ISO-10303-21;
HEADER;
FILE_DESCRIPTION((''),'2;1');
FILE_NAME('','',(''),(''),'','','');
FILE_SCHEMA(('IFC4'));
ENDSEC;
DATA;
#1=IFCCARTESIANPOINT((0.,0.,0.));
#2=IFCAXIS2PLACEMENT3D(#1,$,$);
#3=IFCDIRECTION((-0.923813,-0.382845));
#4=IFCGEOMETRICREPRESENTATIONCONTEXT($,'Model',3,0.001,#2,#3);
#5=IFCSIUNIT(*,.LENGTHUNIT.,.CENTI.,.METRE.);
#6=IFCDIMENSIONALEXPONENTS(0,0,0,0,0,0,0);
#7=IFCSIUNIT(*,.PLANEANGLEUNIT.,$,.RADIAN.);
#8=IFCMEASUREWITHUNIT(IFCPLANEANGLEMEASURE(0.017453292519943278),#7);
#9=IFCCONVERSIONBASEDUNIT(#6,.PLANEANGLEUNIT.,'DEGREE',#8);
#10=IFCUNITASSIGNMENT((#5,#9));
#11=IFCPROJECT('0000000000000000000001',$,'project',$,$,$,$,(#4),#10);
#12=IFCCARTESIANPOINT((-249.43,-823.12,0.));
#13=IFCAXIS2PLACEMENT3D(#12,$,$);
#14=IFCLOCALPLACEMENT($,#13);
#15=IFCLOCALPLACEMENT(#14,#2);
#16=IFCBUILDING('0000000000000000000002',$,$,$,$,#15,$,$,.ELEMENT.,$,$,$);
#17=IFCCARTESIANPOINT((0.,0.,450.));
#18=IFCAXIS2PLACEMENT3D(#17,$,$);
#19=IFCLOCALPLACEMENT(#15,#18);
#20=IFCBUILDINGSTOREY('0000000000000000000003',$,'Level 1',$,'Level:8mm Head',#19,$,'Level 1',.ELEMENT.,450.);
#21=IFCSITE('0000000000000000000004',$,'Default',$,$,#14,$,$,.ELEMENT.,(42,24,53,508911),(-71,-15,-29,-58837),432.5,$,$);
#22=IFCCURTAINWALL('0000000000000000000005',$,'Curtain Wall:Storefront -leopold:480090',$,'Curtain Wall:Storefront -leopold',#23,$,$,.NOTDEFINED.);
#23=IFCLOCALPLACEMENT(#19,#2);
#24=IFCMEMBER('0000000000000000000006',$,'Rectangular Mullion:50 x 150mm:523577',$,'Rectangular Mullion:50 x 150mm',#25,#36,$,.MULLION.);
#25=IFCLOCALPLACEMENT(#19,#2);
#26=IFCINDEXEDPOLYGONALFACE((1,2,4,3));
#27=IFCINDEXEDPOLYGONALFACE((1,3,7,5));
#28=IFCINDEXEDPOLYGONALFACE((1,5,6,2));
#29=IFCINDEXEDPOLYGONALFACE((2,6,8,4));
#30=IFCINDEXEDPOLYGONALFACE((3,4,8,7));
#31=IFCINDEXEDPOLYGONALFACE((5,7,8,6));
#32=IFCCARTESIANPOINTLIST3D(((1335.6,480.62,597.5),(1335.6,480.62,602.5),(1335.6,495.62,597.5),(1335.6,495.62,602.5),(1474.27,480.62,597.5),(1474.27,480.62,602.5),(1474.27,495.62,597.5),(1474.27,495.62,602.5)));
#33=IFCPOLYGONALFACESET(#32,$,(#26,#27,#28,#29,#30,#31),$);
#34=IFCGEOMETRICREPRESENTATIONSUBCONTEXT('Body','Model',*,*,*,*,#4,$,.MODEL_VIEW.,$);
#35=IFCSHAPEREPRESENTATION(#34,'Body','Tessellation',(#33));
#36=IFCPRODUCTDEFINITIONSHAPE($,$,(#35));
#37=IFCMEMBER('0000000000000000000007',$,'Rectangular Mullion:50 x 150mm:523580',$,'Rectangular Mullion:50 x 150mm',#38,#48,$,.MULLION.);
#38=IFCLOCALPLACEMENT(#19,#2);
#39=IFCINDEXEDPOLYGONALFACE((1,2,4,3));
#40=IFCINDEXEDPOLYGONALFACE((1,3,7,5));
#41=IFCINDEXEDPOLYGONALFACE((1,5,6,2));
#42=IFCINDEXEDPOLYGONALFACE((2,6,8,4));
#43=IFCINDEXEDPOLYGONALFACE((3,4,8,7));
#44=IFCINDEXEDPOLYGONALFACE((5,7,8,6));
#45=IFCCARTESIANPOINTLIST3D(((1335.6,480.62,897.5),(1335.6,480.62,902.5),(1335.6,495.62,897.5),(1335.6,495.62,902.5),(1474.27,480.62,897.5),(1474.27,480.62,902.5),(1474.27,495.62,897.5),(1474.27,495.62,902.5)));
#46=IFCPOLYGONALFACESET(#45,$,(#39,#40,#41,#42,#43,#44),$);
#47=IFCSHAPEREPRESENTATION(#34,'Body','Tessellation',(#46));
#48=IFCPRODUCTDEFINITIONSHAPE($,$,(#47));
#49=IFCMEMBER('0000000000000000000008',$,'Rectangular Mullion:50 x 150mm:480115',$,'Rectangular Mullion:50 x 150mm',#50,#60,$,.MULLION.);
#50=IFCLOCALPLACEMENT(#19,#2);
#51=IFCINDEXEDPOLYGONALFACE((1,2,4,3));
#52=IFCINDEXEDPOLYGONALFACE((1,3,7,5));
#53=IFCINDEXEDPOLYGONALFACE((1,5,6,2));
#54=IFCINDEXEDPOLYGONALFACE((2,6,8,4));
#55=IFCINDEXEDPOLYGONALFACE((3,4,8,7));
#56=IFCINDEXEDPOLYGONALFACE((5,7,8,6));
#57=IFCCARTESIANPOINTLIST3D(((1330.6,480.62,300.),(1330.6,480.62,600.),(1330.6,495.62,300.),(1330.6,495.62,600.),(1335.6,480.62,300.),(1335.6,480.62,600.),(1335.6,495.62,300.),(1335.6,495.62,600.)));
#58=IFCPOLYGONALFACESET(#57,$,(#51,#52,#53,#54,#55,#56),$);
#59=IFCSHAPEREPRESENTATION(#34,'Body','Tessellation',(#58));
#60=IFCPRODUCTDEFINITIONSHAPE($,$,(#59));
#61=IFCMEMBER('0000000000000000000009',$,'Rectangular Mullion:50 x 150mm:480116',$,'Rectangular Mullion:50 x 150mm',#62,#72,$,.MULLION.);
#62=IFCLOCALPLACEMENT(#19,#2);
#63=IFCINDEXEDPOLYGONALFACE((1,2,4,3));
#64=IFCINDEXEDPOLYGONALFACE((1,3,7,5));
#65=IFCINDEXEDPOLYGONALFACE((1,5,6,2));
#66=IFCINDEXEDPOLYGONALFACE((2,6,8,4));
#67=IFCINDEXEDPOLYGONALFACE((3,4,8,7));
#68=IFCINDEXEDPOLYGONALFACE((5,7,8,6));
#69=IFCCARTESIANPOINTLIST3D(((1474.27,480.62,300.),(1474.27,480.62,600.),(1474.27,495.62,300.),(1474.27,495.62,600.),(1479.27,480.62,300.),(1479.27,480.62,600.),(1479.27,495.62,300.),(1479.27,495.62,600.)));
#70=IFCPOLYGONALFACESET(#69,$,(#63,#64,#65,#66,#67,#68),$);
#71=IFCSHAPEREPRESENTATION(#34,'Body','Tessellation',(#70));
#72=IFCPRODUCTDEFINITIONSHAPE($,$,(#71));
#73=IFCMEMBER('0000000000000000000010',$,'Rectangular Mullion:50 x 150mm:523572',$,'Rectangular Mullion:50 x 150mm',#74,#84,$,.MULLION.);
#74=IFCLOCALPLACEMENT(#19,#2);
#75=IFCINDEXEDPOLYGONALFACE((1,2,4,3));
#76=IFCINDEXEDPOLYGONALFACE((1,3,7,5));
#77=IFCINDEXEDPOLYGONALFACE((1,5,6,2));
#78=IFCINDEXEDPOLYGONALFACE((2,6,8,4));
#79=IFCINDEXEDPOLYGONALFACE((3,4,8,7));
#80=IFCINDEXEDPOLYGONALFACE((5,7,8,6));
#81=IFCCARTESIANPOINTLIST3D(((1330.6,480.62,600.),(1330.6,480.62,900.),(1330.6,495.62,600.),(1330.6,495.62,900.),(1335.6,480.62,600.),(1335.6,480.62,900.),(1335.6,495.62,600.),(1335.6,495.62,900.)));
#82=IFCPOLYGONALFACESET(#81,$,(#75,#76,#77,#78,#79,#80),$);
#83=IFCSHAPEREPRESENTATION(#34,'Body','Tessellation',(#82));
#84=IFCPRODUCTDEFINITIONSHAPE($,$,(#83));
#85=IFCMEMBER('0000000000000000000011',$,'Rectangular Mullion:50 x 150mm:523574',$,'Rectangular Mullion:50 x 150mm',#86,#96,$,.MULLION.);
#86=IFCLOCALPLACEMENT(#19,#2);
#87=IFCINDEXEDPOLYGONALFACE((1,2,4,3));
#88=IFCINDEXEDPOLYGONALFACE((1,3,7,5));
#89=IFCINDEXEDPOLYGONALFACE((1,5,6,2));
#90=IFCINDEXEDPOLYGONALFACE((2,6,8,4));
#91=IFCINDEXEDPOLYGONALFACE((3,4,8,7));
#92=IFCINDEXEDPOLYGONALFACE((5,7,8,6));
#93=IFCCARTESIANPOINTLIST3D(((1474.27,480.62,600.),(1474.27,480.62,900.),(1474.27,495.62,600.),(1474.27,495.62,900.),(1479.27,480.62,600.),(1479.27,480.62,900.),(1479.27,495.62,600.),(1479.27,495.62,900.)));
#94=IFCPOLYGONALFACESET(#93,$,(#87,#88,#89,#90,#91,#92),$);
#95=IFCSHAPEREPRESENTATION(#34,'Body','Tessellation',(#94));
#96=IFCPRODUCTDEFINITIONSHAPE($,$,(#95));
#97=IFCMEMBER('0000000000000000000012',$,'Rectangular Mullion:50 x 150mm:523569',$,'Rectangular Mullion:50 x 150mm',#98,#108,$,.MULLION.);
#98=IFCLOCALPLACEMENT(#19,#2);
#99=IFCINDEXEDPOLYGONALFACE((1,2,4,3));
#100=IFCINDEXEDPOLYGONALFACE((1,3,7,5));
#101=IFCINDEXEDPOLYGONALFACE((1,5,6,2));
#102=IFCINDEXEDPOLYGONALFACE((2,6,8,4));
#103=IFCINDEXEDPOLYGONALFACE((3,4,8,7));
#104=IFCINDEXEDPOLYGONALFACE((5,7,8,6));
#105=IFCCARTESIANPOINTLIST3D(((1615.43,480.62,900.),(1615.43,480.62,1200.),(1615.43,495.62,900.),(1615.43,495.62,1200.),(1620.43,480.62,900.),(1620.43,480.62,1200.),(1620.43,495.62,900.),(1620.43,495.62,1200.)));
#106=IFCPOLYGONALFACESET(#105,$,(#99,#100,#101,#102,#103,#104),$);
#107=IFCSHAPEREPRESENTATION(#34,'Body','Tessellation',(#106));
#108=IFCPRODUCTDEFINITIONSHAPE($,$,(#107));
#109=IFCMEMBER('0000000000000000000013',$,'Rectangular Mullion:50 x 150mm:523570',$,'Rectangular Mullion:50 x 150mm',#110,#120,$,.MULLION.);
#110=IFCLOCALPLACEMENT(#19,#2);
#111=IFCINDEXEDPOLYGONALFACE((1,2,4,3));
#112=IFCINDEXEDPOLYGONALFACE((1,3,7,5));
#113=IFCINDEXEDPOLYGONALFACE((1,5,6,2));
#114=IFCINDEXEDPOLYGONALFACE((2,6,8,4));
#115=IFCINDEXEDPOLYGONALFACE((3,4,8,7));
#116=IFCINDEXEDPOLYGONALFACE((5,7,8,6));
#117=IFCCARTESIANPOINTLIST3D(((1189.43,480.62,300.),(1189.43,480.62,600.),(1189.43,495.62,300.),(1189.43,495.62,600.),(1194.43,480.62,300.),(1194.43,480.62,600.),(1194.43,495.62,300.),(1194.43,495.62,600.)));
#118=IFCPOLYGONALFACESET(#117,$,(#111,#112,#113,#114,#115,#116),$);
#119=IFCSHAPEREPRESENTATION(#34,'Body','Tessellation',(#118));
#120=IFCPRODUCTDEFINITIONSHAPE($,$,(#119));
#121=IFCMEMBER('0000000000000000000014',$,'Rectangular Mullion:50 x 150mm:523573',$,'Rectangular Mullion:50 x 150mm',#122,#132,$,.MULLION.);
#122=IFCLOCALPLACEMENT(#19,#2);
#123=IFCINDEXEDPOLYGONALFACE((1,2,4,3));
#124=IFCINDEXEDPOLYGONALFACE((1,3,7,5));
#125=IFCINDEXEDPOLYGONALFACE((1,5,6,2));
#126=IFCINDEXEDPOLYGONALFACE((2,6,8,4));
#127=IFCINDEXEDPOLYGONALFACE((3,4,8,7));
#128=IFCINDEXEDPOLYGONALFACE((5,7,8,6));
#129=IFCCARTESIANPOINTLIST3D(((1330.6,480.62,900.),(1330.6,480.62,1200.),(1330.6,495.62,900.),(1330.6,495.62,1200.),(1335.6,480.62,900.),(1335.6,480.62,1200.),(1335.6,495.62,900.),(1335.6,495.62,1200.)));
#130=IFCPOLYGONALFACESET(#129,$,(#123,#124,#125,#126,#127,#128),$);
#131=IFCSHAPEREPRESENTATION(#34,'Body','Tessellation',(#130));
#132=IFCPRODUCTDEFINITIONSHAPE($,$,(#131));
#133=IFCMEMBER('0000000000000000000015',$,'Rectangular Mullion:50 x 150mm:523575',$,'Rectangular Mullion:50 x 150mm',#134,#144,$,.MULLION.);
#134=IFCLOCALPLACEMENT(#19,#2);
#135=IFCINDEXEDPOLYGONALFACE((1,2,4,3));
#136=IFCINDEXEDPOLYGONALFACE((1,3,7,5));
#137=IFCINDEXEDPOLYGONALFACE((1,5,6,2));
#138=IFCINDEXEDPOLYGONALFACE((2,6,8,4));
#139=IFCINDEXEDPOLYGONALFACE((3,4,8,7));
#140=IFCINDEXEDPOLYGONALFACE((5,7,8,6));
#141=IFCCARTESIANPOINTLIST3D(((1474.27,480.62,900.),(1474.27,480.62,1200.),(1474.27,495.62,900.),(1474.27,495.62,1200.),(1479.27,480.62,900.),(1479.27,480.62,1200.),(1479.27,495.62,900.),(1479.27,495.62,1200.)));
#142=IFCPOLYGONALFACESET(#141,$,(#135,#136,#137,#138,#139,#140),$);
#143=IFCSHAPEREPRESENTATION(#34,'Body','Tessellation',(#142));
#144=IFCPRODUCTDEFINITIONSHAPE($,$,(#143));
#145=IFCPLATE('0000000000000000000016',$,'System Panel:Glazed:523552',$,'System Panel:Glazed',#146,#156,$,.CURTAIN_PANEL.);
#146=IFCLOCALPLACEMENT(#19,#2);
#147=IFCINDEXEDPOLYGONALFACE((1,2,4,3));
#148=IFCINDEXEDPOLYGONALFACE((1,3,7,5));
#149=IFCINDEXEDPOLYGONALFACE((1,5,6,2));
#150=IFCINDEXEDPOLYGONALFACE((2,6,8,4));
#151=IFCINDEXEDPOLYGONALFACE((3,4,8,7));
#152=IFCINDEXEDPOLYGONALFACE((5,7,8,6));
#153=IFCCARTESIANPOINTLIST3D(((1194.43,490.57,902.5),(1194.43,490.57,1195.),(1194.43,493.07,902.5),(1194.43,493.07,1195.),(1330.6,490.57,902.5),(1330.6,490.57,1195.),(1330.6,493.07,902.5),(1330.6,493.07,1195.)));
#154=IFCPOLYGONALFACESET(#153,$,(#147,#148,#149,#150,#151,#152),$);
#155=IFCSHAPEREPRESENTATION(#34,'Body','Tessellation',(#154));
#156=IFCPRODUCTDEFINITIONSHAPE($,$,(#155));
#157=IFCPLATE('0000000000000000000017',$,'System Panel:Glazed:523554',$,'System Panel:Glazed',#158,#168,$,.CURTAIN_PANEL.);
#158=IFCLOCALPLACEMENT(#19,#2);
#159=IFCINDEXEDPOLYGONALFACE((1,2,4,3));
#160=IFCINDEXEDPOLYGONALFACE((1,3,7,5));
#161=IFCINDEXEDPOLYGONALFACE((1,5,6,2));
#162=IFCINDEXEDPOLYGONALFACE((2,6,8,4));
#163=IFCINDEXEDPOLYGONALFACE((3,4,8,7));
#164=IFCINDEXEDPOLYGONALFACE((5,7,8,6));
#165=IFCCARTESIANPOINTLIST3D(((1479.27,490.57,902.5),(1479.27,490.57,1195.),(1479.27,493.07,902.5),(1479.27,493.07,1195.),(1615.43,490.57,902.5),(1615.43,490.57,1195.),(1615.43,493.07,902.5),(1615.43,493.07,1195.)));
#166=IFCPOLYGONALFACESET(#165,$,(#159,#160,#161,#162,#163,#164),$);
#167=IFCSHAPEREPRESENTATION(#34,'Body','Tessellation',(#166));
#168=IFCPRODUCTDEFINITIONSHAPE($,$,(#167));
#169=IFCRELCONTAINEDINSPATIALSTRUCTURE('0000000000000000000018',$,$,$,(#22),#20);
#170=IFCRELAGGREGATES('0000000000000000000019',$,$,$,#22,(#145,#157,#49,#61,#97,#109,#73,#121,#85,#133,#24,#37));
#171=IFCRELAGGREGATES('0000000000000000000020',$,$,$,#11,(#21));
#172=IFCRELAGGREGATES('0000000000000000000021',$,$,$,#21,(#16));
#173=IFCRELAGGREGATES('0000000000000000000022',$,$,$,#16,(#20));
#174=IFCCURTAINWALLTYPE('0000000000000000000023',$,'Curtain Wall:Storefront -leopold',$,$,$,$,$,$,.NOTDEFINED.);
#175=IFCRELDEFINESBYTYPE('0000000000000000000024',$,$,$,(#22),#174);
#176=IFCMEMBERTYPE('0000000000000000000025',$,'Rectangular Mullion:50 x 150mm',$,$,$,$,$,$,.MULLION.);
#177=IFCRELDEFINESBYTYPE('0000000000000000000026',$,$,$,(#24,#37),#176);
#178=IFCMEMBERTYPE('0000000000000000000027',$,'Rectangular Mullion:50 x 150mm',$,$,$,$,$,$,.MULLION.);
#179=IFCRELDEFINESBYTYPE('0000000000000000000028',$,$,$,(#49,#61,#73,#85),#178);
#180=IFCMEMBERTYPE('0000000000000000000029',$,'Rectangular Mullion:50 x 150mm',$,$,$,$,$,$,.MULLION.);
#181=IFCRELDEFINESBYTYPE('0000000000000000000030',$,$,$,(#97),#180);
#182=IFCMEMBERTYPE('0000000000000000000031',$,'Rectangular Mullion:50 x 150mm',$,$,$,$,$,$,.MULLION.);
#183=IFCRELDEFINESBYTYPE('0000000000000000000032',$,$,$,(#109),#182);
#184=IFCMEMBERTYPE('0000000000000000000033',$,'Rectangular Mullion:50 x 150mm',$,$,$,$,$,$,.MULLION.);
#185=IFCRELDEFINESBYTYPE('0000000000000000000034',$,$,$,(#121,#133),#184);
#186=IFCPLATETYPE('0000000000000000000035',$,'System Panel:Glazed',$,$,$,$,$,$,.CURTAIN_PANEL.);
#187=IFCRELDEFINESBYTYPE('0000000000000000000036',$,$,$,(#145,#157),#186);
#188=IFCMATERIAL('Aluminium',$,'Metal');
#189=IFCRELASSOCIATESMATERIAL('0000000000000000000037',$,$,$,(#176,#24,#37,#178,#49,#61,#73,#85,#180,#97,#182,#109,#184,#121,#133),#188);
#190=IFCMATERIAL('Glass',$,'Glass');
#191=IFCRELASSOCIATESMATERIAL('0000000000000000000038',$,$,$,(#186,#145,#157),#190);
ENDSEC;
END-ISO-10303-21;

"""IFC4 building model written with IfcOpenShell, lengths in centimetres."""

from ifc_helpers import new_model, entity, si_unit, converted_unit, direction, frame, origin, place, context, subcontext, project, spatial, indexed_curve, outline, extrude, source, transform, mapped, material, type_object, type_shapes, element, aggregate, save


model = new_model("IFC4")

# Units and contexts
model_context = context("Model", 3, precision=0.001, world=origin(), true_north=direction((-0.923813, -0.382845)))
body_context = subcontext(model_context, "Body", "Model", "MODEL_VIEW")
ifc_project = project(units=[si_unit("LENGTHUNIT", "METRE", prefix="CENTI"), converted_unit("PLANEANGLEUNIT", "DEGREE", entity("IfcPlaneAngleMeasure", 0.017453292519943278), si_unit("PLANEANGLEUNIT", "RADIAN"), dimensions=[0, 0, 0, 0, 0, 0, 0])], contexts=[model_context])

# Site, building, storey
site_placement = place(None, frame((-249.43, -823.12, 0.0)))
site = spatial("IfcSite", under=ifc_project, at=site_placement, Name="Default", CompositionType="ELEMENT", RefLatitude=(42, 24, 53, 508911), RefLongitude=(-71, -15, -29, -58837), RefElevation=432.5)
building_placement = place(site_placement, origin())
building = spatial("IfcBuilding", under=site, at=building_placement, CompositionType="ELEMENT")
storey_placement = place(building_placement, frame((0.0, 0.0, 450.0)))
storey = spatial("IfcBuildingStorey", under=building, at=storey_placement, Name="Level 1", ObjectType="Level:8mm Head", LongName="Level 1", CompositionType="ELEMENT", Elevation=450.0)

# Curtain wall, members, plates
curtain_wall_type = type_object("IfcCurtainWallType", Name="Curtain Wall:Storefront -leopold", PredefinedType="NOTDEFINED")
curtain_wall_placement = place(storey_placement, frame((0.0, 0.0, -450.0)))
curtain_wall = element("IfcCurtainWall", 1, at=curtain_wall_placement, inside=storey, type_object=curtain_wall_type, Name="Curtain Wall:Storefront -leopold:480090", ObjectType="Curtain Wall:Storefront -leopold", PredefinedType="NOTDEFINED")
ifc_material_1 = material(Name="Aluminium", Category="Metal")
member_type_1 = type_object("IfcMemberType", Name="Rectangular Mullion:50 x 150mm", PredefinedType="MULLION", material=ifc_material_1)
shared_shape_1 = source(origin(), body_context, "Body", "SweptSolid", [
    extrude(outline(indexed_curve([(-2.5, -7.5), (2.5, -7.5), (2.5, 7.5), (-2.5, 7.5), (-2.5, -7.5)], self_intersect=False)), frame((0.0, 0.0, -138.67), z_axis=(0.0, 0.0, 1.0), x_axis=(-1.0, 0.0, 0.0)), (0.0, 0.0, 1.0), 138.67),
])
type_shapes(member_type_1, [shared_shape_1])
member_1_placement = place(curtain_wall_placement, frame((1474.27, 488.12, 1050.0), z_axis=(1.0, 0.0, 0.0), x_axis=(0.0, 0.0, 1.0)))
member_1 = element("IfcMember", 2, at=member_1_placement, type_object=member_type_1, material=ifc_material_1, Name="Rectangular Mullion:50 x 150mm:523577", ObjectType="Rectangular Mullion:50 x 150mm", PredefinedType="MULLION", context=body_context, shape_type="MappedRepresentation", body=[
    mapped(shared_shape_1, transform((0.0, 0.0, 0.0), scale=1.0)),
])
member_2_placement = place(curtain_wall_placement, frame((1474.27, 488.12, 1350.0), z_axis=(1.0, 0.0, 0.0), x_axis=(0.0, 0.0, 1.0)))
member_2 = element("IfcMember", 3, at=member_2_placement, type_object=member_type_1, material=ifc_material_1, Name="Rectangular Mullion:50 x 150mm:523580", ObjectType="Rectangular Mullion:50 x 150mm", PredefinedType="MULLION", context=body_context, shape_type="MappedRepresentation", body=[
    mapped(shared_shape_1, transform((0.0, 0.0, 0.0), scale=1.0)),
])
member_type_2 = type_object("IfcMemberType", Name="Rectangular Mullion:50 x 150mm", PredefinedType="MULLION", material=ifc_material_1)
shared_shape_2 = source(origin(), body_context, "Body", "SweptSolid", [
    extrude(outline(indexed_curve([(-2.5, -7.5), (2.5, -7.5), (2.5, 7.5), (-2.5, 7.5), (-2.5, -7.5)], self_intersect=False)), frame((0.0, 0.0, -300.0), z_axis=(0.0, 0.0, 1.0), x_axis=(-1.0, 0.0, 0.0)), (0.0, 0.0, 1.0), 300.0),
])
type_shapes(member_type_2, [shared_shape_2])
member_3_placement = place(curtain_wall_placement, frame((1333.1, 488.12, 750.0), z_axis=(0.0, 0.0, -1.0), x_axis=(1.0, 0.0, 0.0)))
member_3 = element("IfcMember", 4, at=member_3_placement, type_object=member_type_2, material=ifc_material_1, Name="Rectangular Mullion:50 x 150mm:480115", ObjectType="Rectangular Mullion:50 x 150mm", PredefinedType="MULLION", context=body_context, shape_type="MappedRepresentation", body=[
    mapped(shared_shape_2, transform((0.0, 0.0, 0.0), scale=1.0)),
])
member_4_placement = place(curtain_wall_placement, frame((1476.77, 488.12, 750.0), z_axis=(0.0, 0.0, -1.0), x_axis=(1.0, 0.0, 0.0)))
member_4 = element("IfcMember", 5, at=member_4_placement, type_object=member_type_2, material=ifc_material_1, Name="Rectangular Mullion:50 x 150mm:480116", ObjectType="Rectangular Mullion:50 x 150mm", PredefinedType="MULLION", context=body_context, shape_type="MappedRepresentation", body=[
    mapped(shared_shape_2, transform((0.0, 0.0, 0.0), scale=1.0)),
])
member_5_placement = place(curtain_wall_placement, frame((1333.1, 488.12, 1050.0), z_axis=(0.0, 0.0, -1.0), x_axis=(1.0, 0.0, 0.0)))
member_5 = element("IfcMember", 6, at=member_5_placement, type_object=member_type_2, material=ifc_material_1, Name="Rectangular Mullion:50 x 150mm:523572", ObjectType="Rectangular Mullion:50 x 150mm", PredefinedType="MULLION", context=body_context, shape_type="MappedRepresentation", body=[
    mapped(shared_shape_2, transform((0.0, 0.0, 0.0), scale=1.0)),
])
member_6_placement = place(curtain_wall_placement, frame((1476.77, 488.12, 1050.0), z_axis=(0.0, 0.0, -1.0), x_axis=(1.0, 0.0, 0.0)))
member_6 = element("IfcMember", 7, at=member_6_placement, type_object=member_type_2, material=ifc_material_1, Name="Rectangular Mullion:50 x 150mm:523574", ObjectType="Rectangular Mullion:50 x 150mm", PredefinedType="MULLION", context=body_context, shape_type="MappedRepresentation", body=[
    mapped(shared_shape_2, transform((0.0, 0.0, 0.0), scale=1.0)),
])
member_type_3 = type_object("IfcMemberType", Name="Rectangular Mullion:50 x 150mm", PredefinedType="MULLION", material=ifc_material_1)
shared_shape_3 = source(origin(), body_context, "Body", "SweptSolid", [
    extrude(outline(indexed_curve([(-2.5, -7.5), (2.5, -7.5), (2.5, 7.5), (-2.5, 7.5), (-2.5, -7.5)], self_intersect=False)), frame((-2.5, 0.0, -300.0), z_axis=(0.0, 0.0, 1.0), x_axis=(-1.0, 0.0, 0.0)), (0.0, 0.0, 1.0), 300.0),
])
type_shapes(member_type_3, [shared_shape_3])
member_7_placement = place(curtain_wall_placement, frame((1620.43, 488.12, 1350.0), z_axis=(0.0, 0.0, -1.0), x_axis=(1.0, 0.0, 0.0)))
member_7 = element("IfcMember", 8, at=member_7_placement, type_object=member_type_3, material=ifc_material_1, Name="Rectangular Mullion:50 x 150mm:523569", ObjectType="Rectangular Mullion:50 x 150mm", PredefinedType="MULLION", context=body_context, shape_type="MappedRepresentation", body=[
    mapped(shared_shape_3, transform((0.0, 0.0, 0.0), scale=1.0)),
])
member_type_4 = type_object("IfcMemberType", Name="Rectangular Mullion:50 x 150mm", PredefinedType="MULLION", material=ifc_material_1)
shared_shape_4 = source(origin(), body_context, "Body", "SweptSolid", [
    extrude(outline(indexed_curve([(-2.5, -7.5), (2.5, -7.5), (2.5, 7.5), (-2.5, 7.5), (-2.5, -7.5)], self_intersect=False)), frame((-2.5, 0.0, -300.0), z_axis=(0.0, 0.0, 1.0), x_axis=(-1.0, 0.0, 0.0)), (0.0, 0.0, 1.0), 300.0),
])
type_shapes(member_type_4, [shared_shape_4])
member_8_placement = place(curtain_wall_placement, frame((1189.43, 488.12, 1050.0), z_axis=(0.0, 0.0, 1.0), x_axis=(-1.0, 0.0, 0.0)))
member_8 = element("IfcMember", 9, at=member_8_placement, type_object=member_type_4, material=ifc_material_1, Name="Rectangular Mullion:50 x 150mm:523570", ObjectType="Rectangular Mullion:50 x 150mm", PredefinedType="MULLION", context=body_context, shape_type="MappedRepresentation", body=[
    mapped(shared_shape_4, transform((0.0, 0.0, 0.0), scale=1.0)),
])
member_type_5 = type_object("IfcMemberType", Name="Rectangular Mullion:50 x 150mm", PredefinedType="MULLION", material=ifc_material_1)
shared_shape_5 = source(origin(), body_context, "Body", "SweptSolid", [
    extrude(outline(indexed_curve([(-2.5, -7.5), (2.5, -7.5), (2.5, 7.5), (-2.5, 7.5), (-2.5, -7.5)], self_intersect=False)), frame((0.0, 0.0, -300.0), z_axis=(0.0, 0.0, 1.0), x_axis=(-1.0, 0.0, 0.0)), (0.0, 0.0, 1.0), 300.0),
])
type_shapes(member_type_5, [shared_shape_5])
member_9_placement = place(curtain_wall_placement, frame((1333.1, 488.12, 1350.0), z_axis=(0.0, 0.0, -1.0), x_axis=(1.0, 0.0, 0.0)))
member_9 = element("IfcMember", 10, at=member_9_placement, type_object=member_type_5, material=ifc_material_1, Name="Rectangular Mullion:50 x 150mm:523573", ObjectType="Rectangular Mullion:50 x 150mm", PredefinedType="MULLION", context=body_context, shape_type="MappedRepresentation", body=[
    mapped(shared_shape_5, transform((0.0, 0.0, 0.0), scale=1.0)),
])
member_10_placement = place(curtain_wall_placement, frame((1476.77, 488.12, 1350.0), z_axis=(0.0, 0.0, -1.0), x_axis=(1.0, 0.0, 0.0)))
member_10 = element("IfcMember", 11, at=member_10_placement, type_object=member_type_5, material=ifc_material_1, Name="Rectangular Mullion:50 x 150mm:523575", ObjectType="Rectangular Mullion:50 x 150mm", PredefinedType="MULLION", context=body_context, shape_type="MappedRepresentation", body=[
    mapped(shared_shape_5, transform((0.0, 0.0, 0.0), scale=1.0)),
])
ifc_material_2 = material(Name="Glass", Category="Glass")
plate_type_1 = type_object("IfcPlateType", Name="System Panel:Glazed", PredefinedType="CURTAIN_PANEL", material=ifc_material_2)
shared_shape_6 = source(origin(), body_context, "Body", "SweptSolid", [
    extrude(outline(indexed_curve([(-1.25, -68.08), (1.25, -68.08), (1.25, 68.08), (-1.25, 68.08), (-1.25, -68.08)], self_intersect=False)), frame((0.0, 3.7, 0.0), z_axis=(0.0, 0.0, 1.0), x_axis=(0.0, 1.0, 0.0)), (0.0, 0.0, 1.0), 292.5),
])
type_shapes(plate_type_1, [shared_shape_6])
plate_1_placement = place(curtain_wall_placement, frame((1262.52, 488.12, 1352.5)))
plate_1 = element("IfcPlate", 12, at=plate_1_placement, type_object=plate_type_1, material=ifc_material_2, Name="System Panel:Glazed:523552", ObjectType="System Panel:Glazed", PredefinedType="CURTAIN_PANEL", context=body_context, shape_type="MappedRepresentation", body=[
    mapped(shared_shape_6, transform((0.0, 0.0, 0.0), scale=1.0)),
])
plate_2_placement = place(curtain_wall_placement, frame((1547.35, 488.12, 1352.5)))
plate_2 = element("IfcPlate", 13, at=plate_2_placement, type_object=plate_type_1, material=ifc_material_2, Name="System Panel:Glazed:523554", ObjectType="System Panel:Glazed", PredefinedType="CURTAIN_PANEL", context=body_context, shape_type="MappedRepresentation", body=[
    mapped(shared_shape_6, transform((0.0, 0.0, 0.0), scale=1.0)),
])
aggregate(curtain_wall, [plate_1, plate_2, member_3, member_4, member_7, member_8, member_5, member_9, member_6, member_10, member_1, member_2])

save(model, "model.ifc")
